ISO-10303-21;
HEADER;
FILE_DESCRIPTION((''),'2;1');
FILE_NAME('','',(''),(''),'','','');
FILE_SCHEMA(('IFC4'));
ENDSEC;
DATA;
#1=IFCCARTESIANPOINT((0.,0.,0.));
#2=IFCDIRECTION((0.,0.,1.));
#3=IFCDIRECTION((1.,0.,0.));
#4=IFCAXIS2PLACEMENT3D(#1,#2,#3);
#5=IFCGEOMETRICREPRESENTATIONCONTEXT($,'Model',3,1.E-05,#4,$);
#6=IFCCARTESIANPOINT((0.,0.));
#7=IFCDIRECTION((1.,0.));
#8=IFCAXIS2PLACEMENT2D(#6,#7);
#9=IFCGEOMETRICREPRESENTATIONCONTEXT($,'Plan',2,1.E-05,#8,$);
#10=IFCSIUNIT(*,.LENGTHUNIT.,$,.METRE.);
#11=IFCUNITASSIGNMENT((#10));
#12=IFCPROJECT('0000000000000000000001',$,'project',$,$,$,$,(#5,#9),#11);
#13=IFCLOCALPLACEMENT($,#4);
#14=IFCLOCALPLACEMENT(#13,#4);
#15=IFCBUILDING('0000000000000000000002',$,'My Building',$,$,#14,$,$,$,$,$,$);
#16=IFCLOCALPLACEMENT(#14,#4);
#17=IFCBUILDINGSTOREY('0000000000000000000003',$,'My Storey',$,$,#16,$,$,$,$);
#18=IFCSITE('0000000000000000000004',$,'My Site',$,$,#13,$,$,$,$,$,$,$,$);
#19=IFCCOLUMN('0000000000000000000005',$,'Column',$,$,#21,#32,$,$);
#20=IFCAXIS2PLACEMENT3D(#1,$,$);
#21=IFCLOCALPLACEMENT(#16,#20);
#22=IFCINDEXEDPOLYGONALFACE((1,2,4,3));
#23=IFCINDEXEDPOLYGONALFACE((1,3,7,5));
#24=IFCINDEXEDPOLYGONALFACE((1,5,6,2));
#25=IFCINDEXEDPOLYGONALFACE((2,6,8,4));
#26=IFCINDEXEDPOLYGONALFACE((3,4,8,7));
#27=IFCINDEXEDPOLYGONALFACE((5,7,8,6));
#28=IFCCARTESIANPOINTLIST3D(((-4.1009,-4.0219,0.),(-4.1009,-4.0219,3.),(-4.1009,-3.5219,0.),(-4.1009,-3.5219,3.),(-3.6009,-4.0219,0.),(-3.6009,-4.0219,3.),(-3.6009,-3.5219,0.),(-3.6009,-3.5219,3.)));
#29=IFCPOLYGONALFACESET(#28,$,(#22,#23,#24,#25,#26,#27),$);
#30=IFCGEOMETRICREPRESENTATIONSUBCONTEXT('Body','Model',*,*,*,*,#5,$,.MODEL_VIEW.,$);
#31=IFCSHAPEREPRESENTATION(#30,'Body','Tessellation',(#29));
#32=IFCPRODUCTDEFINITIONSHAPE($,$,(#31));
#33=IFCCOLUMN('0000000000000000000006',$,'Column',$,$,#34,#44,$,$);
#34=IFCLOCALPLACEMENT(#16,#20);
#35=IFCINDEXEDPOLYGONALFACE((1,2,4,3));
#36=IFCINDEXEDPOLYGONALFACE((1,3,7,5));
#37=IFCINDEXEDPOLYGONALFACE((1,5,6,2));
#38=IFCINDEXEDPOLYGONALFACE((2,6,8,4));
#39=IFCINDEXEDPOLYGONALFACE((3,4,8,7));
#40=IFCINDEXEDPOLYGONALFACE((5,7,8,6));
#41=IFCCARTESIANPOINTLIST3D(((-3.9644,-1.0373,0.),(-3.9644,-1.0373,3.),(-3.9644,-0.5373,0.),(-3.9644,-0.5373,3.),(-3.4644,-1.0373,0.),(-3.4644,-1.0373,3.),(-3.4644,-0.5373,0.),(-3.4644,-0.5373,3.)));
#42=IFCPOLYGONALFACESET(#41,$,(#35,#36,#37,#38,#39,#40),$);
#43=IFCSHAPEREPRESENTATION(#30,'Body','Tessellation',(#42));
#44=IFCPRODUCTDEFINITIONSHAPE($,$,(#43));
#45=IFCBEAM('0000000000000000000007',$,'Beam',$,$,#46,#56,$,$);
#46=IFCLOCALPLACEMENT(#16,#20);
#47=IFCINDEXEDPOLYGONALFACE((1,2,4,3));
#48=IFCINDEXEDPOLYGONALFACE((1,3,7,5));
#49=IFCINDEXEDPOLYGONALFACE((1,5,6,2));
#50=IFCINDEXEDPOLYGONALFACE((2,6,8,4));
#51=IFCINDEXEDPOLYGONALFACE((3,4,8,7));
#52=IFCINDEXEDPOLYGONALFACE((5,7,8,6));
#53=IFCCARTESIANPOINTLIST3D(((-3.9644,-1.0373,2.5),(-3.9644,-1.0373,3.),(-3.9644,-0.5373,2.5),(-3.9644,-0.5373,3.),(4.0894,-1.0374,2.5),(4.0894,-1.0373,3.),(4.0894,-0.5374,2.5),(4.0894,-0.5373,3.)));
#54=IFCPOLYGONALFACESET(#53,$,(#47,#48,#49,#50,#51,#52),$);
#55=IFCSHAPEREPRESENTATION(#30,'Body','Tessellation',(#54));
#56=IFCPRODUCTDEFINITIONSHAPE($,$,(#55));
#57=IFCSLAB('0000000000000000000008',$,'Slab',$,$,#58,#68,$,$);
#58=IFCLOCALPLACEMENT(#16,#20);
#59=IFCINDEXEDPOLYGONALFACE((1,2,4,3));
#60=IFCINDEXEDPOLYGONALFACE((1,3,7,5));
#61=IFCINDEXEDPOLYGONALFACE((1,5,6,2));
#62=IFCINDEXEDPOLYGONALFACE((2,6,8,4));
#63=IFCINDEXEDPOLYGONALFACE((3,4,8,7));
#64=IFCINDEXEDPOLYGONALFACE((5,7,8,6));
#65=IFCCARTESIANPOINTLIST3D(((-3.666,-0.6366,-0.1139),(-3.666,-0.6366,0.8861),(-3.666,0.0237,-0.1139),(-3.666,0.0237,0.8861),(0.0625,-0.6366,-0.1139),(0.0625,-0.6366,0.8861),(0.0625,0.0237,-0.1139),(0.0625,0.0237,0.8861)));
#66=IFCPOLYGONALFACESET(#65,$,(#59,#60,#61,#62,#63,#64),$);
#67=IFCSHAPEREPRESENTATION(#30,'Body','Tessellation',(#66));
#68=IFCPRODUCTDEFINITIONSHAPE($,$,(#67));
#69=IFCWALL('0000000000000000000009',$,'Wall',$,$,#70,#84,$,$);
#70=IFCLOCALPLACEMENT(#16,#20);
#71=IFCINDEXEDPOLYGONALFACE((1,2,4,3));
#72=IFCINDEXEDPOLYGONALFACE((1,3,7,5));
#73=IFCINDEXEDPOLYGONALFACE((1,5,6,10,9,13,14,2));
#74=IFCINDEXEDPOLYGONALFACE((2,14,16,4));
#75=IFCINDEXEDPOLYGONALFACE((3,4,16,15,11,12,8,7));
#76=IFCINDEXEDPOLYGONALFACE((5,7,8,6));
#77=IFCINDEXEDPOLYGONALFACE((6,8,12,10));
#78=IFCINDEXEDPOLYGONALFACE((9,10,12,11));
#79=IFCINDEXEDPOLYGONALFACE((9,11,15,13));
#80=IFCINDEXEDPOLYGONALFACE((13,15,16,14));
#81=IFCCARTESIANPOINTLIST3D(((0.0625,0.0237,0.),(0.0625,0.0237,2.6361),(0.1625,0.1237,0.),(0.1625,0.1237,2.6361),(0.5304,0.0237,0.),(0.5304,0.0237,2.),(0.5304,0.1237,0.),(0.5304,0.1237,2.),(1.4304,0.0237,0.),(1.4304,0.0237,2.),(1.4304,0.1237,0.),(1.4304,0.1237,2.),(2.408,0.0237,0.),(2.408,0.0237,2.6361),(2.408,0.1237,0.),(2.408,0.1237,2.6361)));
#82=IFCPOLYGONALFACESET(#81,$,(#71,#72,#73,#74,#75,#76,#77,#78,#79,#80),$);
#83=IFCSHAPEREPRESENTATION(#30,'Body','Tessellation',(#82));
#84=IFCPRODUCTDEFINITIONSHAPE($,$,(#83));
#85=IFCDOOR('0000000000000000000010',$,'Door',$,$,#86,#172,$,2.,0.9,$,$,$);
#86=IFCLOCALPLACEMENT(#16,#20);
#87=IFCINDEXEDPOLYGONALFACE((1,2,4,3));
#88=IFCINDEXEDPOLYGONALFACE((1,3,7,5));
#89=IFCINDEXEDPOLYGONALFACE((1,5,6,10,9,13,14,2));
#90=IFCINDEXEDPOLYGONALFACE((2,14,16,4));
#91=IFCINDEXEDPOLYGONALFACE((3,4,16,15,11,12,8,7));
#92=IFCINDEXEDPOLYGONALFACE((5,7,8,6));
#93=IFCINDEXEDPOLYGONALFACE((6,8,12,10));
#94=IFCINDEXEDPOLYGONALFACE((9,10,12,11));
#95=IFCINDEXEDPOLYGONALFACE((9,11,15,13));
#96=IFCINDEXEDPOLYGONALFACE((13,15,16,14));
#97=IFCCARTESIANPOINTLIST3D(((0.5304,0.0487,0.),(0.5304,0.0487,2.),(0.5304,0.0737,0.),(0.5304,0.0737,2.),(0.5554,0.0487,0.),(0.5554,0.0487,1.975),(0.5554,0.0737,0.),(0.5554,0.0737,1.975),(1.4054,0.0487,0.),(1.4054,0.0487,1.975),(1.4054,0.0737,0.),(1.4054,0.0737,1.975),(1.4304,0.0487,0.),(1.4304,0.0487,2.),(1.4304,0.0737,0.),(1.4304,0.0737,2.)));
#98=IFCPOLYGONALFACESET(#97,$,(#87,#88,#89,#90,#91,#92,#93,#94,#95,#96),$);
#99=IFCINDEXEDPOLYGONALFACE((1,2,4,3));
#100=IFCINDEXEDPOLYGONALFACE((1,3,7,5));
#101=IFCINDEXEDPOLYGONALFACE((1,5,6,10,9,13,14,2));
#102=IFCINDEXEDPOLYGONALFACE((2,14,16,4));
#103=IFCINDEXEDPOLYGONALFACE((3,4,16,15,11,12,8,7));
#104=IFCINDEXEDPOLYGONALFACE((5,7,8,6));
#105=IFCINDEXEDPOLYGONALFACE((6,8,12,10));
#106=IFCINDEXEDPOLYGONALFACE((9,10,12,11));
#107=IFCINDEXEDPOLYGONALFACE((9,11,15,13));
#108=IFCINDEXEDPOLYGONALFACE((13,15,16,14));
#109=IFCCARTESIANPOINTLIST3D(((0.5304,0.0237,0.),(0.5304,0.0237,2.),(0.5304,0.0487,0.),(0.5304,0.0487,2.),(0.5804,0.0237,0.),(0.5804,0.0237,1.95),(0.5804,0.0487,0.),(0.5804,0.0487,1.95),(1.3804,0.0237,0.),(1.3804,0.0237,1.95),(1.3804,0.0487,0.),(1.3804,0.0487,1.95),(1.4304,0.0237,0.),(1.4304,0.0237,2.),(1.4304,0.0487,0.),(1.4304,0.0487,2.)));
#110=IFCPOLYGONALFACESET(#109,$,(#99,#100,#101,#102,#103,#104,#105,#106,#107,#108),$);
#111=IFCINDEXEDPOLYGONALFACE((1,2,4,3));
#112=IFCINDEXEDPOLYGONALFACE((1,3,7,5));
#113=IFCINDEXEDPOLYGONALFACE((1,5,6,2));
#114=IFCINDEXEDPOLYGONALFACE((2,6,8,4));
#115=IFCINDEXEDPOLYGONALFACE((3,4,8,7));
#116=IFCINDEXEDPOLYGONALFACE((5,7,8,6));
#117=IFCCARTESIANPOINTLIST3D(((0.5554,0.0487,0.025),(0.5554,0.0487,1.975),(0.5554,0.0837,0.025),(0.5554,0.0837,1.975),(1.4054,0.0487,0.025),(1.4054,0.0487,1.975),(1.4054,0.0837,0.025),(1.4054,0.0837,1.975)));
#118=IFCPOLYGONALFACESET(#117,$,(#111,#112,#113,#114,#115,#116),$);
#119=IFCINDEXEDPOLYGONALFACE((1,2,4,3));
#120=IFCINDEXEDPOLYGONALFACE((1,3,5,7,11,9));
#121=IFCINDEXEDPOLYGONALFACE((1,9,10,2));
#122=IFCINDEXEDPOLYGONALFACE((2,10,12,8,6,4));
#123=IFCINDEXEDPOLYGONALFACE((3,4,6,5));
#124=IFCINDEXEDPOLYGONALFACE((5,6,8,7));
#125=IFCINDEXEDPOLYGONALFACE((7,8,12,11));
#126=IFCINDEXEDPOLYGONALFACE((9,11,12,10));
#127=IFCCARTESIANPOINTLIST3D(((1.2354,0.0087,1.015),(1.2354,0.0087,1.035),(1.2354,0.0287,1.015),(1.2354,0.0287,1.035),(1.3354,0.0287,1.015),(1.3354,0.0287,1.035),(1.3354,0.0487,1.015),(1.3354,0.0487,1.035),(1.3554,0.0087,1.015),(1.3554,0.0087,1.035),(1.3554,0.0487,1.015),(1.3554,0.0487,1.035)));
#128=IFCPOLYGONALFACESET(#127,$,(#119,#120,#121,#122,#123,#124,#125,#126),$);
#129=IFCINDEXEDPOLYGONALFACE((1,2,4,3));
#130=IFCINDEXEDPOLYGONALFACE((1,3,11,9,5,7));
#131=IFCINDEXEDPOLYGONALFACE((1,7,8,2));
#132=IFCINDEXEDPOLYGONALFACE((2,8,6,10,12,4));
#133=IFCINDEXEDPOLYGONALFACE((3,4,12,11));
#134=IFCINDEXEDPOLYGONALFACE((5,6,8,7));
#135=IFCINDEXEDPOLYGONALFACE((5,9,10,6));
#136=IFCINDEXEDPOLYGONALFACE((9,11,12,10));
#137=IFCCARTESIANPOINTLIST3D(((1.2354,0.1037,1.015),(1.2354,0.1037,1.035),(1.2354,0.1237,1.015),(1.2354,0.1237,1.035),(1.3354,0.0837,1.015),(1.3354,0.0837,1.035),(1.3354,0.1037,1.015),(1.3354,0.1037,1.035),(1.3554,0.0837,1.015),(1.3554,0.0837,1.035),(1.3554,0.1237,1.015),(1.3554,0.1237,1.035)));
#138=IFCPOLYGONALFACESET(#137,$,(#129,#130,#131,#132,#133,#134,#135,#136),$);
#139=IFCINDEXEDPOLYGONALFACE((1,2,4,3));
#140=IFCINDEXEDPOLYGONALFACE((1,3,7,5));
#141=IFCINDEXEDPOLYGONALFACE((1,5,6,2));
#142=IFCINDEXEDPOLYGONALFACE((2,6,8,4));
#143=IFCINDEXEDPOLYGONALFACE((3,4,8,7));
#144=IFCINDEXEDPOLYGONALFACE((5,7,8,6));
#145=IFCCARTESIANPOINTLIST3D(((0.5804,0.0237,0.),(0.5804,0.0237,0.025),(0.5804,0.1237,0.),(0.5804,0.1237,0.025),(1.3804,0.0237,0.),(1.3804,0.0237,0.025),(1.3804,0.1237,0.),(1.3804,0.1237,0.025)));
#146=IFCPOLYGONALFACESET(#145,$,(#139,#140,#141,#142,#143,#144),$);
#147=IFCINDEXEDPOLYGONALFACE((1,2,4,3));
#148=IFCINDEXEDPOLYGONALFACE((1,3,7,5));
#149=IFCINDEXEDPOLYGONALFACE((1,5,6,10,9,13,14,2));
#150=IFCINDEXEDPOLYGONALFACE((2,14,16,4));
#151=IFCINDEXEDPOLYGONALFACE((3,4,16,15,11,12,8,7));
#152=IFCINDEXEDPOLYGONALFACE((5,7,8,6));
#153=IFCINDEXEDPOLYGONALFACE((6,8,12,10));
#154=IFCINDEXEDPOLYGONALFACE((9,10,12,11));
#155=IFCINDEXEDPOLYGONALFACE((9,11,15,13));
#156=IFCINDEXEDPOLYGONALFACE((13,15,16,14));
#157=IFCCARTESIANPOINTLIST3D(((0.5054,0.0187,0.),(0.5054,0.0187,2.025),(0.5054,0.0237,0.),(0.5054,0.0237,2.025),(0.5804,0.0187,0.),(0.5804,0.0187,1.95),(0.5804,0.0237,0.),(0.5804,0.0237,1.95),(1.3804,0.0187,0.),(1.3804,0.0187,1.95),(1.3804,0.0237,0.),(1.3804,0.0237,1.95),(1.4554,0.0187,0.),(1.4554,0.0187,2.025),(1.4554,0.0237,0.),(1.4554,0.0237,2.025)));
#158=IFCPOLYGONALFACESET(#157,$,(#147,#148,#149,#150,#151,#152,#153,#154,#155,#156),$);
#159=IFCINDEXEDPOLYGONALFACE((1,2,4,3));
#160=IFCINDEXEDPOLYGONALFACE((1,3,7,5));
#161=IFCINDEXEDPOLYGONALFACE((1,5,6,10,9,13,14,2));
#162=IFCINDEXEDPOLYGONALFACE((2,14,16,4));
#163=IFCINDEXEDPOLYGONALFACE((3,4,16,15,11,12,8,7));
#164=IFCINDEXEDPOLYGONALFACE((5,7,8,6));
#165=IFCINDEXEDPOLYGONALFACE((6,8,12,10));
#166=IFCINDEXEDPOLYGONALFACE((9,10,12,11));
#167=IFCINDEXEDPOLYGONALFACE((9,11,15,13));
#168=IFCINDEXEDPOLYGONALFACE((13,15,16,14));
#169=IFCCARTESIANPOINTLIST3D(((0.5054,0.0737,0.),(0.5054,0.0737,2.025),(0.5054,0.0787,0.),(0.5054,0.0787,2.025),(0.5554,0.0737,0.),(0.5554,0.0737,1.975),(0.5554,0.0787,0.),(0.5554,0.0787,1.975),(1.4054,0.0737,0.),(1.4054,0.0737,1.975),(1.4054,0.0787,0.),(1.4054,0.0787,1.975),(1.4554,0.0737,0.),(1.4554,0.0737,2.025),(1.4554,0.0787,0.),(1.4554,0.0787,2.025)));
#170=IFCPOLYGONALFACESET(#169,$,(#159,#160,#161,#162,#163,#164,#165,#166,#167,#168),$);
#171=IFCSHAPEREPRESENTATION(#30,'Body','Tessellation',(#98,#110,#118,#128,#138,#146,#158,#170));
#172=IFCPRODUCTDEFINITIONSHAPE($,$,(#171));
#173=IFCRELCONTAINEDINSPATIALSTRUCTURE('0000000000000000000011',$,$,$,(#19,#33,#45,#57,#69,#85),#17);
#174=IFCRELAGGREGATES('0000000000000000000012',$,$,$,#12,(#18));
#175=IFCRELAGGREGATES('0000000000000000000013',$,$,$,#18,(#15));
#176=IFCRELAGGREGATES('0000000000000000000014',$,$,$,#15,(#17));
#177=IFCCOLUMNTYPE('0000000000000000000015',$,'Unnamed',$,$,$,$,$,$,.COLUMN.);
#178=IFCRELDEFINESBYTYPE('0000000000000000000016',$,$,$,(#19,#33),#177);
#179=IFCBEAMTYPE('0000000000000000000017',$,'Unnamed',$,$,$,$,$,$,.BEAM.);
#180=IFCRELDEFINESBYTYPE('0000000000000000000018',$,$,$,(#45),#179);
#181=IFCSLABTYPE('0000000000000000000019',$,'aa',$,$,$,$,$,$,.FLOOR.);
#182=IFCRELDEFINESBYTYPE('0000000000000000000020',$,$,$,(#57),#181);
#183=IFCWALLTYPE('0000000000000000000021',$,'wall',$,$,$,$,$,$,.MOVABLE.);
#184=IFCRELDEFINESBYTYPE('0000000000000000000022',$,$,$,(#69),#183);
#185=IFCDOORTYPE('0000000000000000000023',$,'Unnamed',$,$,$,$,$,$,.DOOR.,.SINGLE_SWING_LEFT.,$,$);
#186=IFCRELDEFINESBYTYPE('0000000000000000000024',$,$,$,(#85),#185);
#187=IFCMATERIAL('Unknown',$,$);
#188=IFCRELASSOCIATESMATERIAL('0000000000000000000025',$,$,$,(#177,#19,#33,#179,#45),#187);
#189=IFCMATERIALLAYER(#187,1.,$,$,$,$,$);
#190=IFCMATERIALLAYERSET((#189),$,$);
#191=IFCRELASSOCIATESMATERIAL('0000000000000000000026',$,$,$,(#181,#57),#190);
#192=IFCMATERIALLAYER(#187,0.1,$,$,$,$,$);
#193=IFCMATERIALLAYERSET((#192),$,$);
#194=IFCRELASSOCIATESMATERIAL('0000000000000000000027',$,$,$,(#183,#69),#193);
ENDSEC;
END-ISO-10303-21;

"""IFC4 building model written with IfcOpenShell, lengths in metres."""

from ifc_helpers import new_model, entity, si_unit, frame, origin_with_axes, origin_2d_with_axis, place, context, subcontext, project, spatial, line, indexed_curve, rectangle, outline, extrude, shape, source, transform, mapped, material, layer, layer_set, layer_usage, material_profile, profile_set, profile_usage, type_object, type_shapes, element, fill, save


model = new_model("IFC4")

# Units and contexts
model_context = context("Model", 3, precision=1e-05, world=origin_with_axes())
plan_context = context("Plan", 2, precision=1e-05, world=origin_2d_with_axis())
body_context_1 = subcontext(model_context, "Body", "Model", "MODEL_VIEW")
body_context_2 = subcontext(plan_context, "Body", "Plan", "PLAN_VIEW")
ifc_project = project(units=[si_unit("LENGTHUNIT", "METRE")], contexts=[model_context, plan_context])

# Site, building, storey
site_placement = place(None, origin_with_axes())
site = spatial("IfcSite", under=ifc_project, at=site_placement, Name="My Site")
building_placement = place(site_placement, origin_with_axes())
building = spatial("IfcBuilding", under=site, at=building_placement, Name="My Building")
storey_placement = place(building_placement, origin_with_axes())
storey = spatial("IfcBuildingStorey", under=building, at=storey_placement, Name="My Storey")

# Columns
ifc_material = material(Name="Unknown")
ifc_material_profile_1 = material_profile(ifc_material, rectangle(XDim=0.5, YDim=0.5))
ifc_profile_set_1 = profile_set([ifc_material_profile_1])
ifc_profile_usage_1 = profile_usage(ifc_profile_set_1, cardinal=5)
column_type = type_object("IfcColumnType", Name="Unnamed", PredefinedType="COLUMN", material=ifc_profile_set_1)
column_1_placement = place(storey_placement, frame((-3.8509, -3.7719, 0.0), z_axis=(0.0, 0.0, 1.0), x_axis=(1.0, 0.0, 0.0)))
element("IfcColumn", 1, at=column_1_placement, inside=storey, type_object=column_type, material=ifc_profile_usage_1, Name="Column", context=body_context_1, shape_type="SweptSolid", body=[
    extrude(rectangle(XDim=0.5, YDim=0.5), origin_with_axes(), (0.0, 0.0, 1.0), 3.0),
])
ifc_profile_usage_2 = profile_usage(ifc_profile_set_1, cardinal=5)
column_2_placement = place(storey_placement, frame((-3.7144, -0.7873, 0.0), z_axis=(0.0, 0.0, 1.0), x_axis=(1.0, 0.0, 0.0)))
element("IfcColumn", 2, at=column_2_placement, inside=storey, type_object=column_type, material=ifc_profile_usage_2, Name="Column", context=body_context_1, shape_type="SweptSolid", body=[
    extrude(rectangle(XDim=0.5, YDim=0.5), origin_with_axes(), (0.0, 0.0, 1.0), 3.0),
])

# Beam
ifc_material_profile_2 = material_profile(ifc_material, rectangle(XDim=0.5, YDim=0.5))
ifc_profile_set_2 = profile_set([ifc_material_profile_2])
ifc_profile_usage_3 = profile_usage(ifc_profile_set_2, cardinal=5)
beam_type = type_object("IfcBeamType", Name="Unnamed", PredefinedType="BEAM", material=ifc_profile_set_2)
beam_placement = place(storey_placement, frame((-3.9644, -0.7873, 2.75), z_axis=(1.0, 0.0, 0.0), x_axis=(0.0, 1.0, 0.0)))
element("IfcBeam", 3, at=beam_placement, inside=storey, type_object=beam_type, material=ifc_profile_usage_3, Name="Beam", context=body_context_1, shape_type="SweptSolid", body=[
    extrude(rectangle(XDim=0.5, YDim=0.5), origin_with_axes(), (0.0, 0.0, 1.0), 8.0538),
])

# Slab
ifc_layer_1 = layer(ifc_material, 1.0)
ifc_layer_set_1 = layer_set([ifc_layer_1])
ifc_layer_usage_1 = layer_usage(ifc_layer_set_1, "AXIS3", "POSITIVE", -1.0)
slab_type = type_object("IfcSlabType", Name="aa", PredefinedType="FLOOR", material=ifc_layer_set_1)
slab_placement = place(storey_placement, frame((0.0625, 0.0237, 0.8861), z_axis=(0.0, 0.0, 1.0), x_axis=(1.0, 0.0, 0.0)))
element("IfcSlab", 4, at=slab_placement, inside=storey, type_object=slab_type, material=ifc_layer_usage_1, Name="Slab", context=body_context_1, shape_type="SweptSolid", body=[
    extrude(outline(indexed_curve([(0.0, 0.0), (0.0, -0.6603), (-3.7285, -0.6603), (-3.7285, 0.0), (0.0, 0.0)])), frame((0.0, 0.0, -1.0), z_axis=(0.0, 0.0, 1.0), x_axis=(1.0, 0.0, 0.0)), (0.0, 0.0, 1.0), 1.0),
])

# Wall, opening, door
ifc_layer_2 = layer(ifc_material, 0.1)
ifc_layer_set_2 = layer_set([ifc_layer_2])
ifc_layer_usage_2 = layer_usage(ifc_layer_set_2, "AXIS2", "POSITIVE", 0.0)
wall_type = type_object("IfcWallType", Name="wall", PredefinedType="MOVABLE", material=ifc_layer_set_2)
wall_placement = place(storey_placement, frame((0.0625, 0.0237, 0.0), z_axis=(0.0, 0.0, 1.0), x_axis=(1.0, 0.0, 0.0)))
wall = element("IfcWall", 5, at=wall_placement, inside=storey, type_object=wall_type, material=ifc_layer_usage_2, Name="Wall", context=body_context_1, shape_type="SweptSolid", body=[
    extrude(outline(indexed_curve([(0.0, 0.0), (0.1, 0.1), (2.3454, 0.1), (2.3454, 0.0)], segments=[line(1, 2, 3, 4, 1)])), origin_with_axes(), (0.0, 0.0, 1.0), 2.6361),
])
shared_shape_1 = source(origin_with_axes(), body_context_1, "Body", "SweptSolid", [
    extrude(outline(indexed_curve([(0.0, 0.0), (0.9, 0.0), (0.9, 2.0), (0.0, 2.0)], segments=[line(1, 2, 3, 4, 1)])), frame((0.0, -0.6, 0.0), z_axis=(0.0, -1.0, 0.0), x_axis=(1.0, 0.0, 0.0)), (0.0, 0.0, -1.0), 1.2),
])
opening_placement = place(wall_placement, frame((0.4679, 0.0, 0.0), z_axis=(0.0, 0.0, 1.0), x_axis=(1.0, 0.0, 0.0)))
opening = element("IfcOpeningElement", 6, at=opening_placement, cuts=wall, PredefinedType="OPENING", context=body_context_1, shape_type="MappedRepresentation", body=[
    mapped(shared_shape_1, transform((0.0, 0.0, 0.0), x_axis=(1.0, 0.0, 0.0), y_axis=(0.0, 1.0, 0.0), z_axis=(0.0, 0.0, 1.0), scale=1.0)),
])
door_type = type_object("IfcDoorType", Name="Unnamed", OperationType="SINGLE_SWING_LEFT", PredefinedType="DOOR")
shared_shape_2 = source(origin_with_axes(), body_context_1, "Body", "SweptSolid", [
    extrude(outline(indexed_curve([(0.0, 0.0), (0.0, 2.0), (0.9, 2.0), (0.9, 0.0), (0.875, 0.0), (0.875, 1.975), (0.025, 1.975), (0.025, 0.0)], segments=[line(1, 2, 3, 4, 5, 6, 7, 8, 1)])), frame((0.0, 0.025, 0.0), z_axis=(0.0, -1.0, 0.0), x_axis=(1.0, 0.0, 0.0)), (0.0, 0.0, -1.0), 0.025),
    extrude(outline(indexed_curve([(0.0, 0.0), (0.0, 2.0), (0.9, 2.0), (0.9, 0.0), (0.85, 0.0), (0.85, 1.95), (0.05, 1.95), (0.05, 0.0)], segments=[line(1, 2, 3, 4, 5, 6, 7, 8, 1)])), frame((0.0, 0.0, 0.0), z_axis=(0.0, -1.0, 0.0), x_axis=(1.0, 0.0, 0.0)), (0.0, 0.0, -1.0), 0.025),
    extrude(outline(indexed_curve([(0.0, 0.0), (0.85, 0.0), (0.85, 0.035), (0.0, 0.035)], segments=[line(1, 2, 3, 4, 1)])), frame((0.025, 0.025, 0.025), z_axis=(0.0, 0.0, 1.0), x_axis=(1.0, 0.0, 0.0)), (0.0, 0.0, 1.0), 1.95),
    extrude(outline(indexed_curve([(0.0, 0.0), (0.0, -0.04), (-0.12, -0.04), (-0.12, -0.02), (-0.02, -0.02), (-0.02, 0.0)], segments=[line(1, 2, 3, 4, 5, 6, 1)])), frame((0.825, 0.025, 1.015), z_axis=(0.0, 0.0, 1.0), x_axis=(1.0, 0.0, 0.0)), (0.0, 0.0, 1.0), 0.02),
    extrude(outline(indexed_curve([(0.0, 0.0), (0.0, 0.04), (-0.12, 0.04), (-0.12, 0.02), (-0.02, 0.02), (-0.02, 0.0)], segments=[line(1, 2, 3, 4, 5, 6, 1)])), frame((0.825, 0.06, 1.015), z_axis=(0.0, 0.0, 1.0), x_axis=(1.0, 0.0, 0.0)), (0.0, 0.0, 1.0), 0.02),
    extrude(outline(indexed_curve([(0.0, 0.0), (0.8, 0.0), (0.8, 0.1), (0.0, 0.1)], segments=[line(1, 2, 3, 4, 1)])), frame((0.05, 0.0, 0.0), z_axis=(0.0, 0.0, 1.0), x_axis=(1.0, 0.0, 0.0)), (0.0, 0.0, 1.0), 0.025),
    extrude(outline(indexed_curve([(0.0, 0.0), (0.0, 2.025), (0.95, 2.025), (0.95, 0.0), (0.875, 0.0), (0.875, 1.95), (0.075, 1.95), (0.075, 0.0)], segments=[line(1, 2, 3, 4, 5, 6, 7, 8, 1)])), frame((-0.025, -0.005, 0.0), z_axis=(0.0, -1.0, 0.0), x_axis=(1.0, 0.0, 0.0)), (0.0, 0.0, -1.0), 0.005),
    extrude(outline(indexed_curve([(0.0, 0.0), (0.0, 2.025), (0.95, 2.025), (0.95, 0.0), (0.9, 0.0), (0.9, 1.975), (0.05, 1.975), (0.05, 0.0)], segments=[line(1, 2, 3, 4, 5, 6, 7, 8, 1)])), frame((-0.025, 0.05, 0.0), z_axis=(0.0, -1.0, 0.0), x_axis=(1.0, 0.0, 0.0)), (0.0, 0.0, -1.0), 0.005),
])
shared_shape_3 = source(origin_with_axes(), body_context_2, "Body", "Curve2D", [
    entity("IfcIndexedPolyCurve", entity("IfcCartesianPointList2D", [[0.0, 0.0], [0.0, 0.05], [0.025, 0.05], [0.025, 0.025], [0.05, 0.025], [0.05, 0.0]]), [entity("IfcLineIndex", [1, 2, 3, 4, 5, 6, 1])]),
    entity("IfcIndexedPolyCurve", entity("IfcCartesianPointList2D", [[0.9, 0.0], [0.9, 0.05], [0.875, 0.05], [0.875, 0.025], [0.85, 0.025], [0.85, 0.0]]), [entity("IfcLineIndex", [1, 2, 3, 4, 5, 6, 1])]),
    entity("IfcTrimmedCurve", entity("IfcEllipse", entity("IfcAxis2Placement2D", entity("IfcCartesianPoint", [0.06, 0.05]), entity("IfcDirection", [1.0, 0.0])), 0.815, 0.85), [entity("IfcCartesianPoint", [0.875, 0.05])], [entity("IfcCartesianPoint", [0.06, 0.9])], True, "CARTESIAN"),
    entity("IfcIndexedPolyCurve", entity("IfcCartesianPointList2D", [[0.025, 0.05], [0.06, 0.05], [0.06, 0.9], [0.025, 0.9]]), [entity("IfcLineIndex", [1, 2, 3, 4, 1])]),
])
type_shapes(door_type, [shared_shape_2, shared_shape_3])
door_placement = place(opening_placement, origin_with_axes())
door = element("IfcDoor", 7, at=door_placement, inside=storey, type_object=door_type, Name="Door", OverallHeight=2.0, OverallWidth=0.9, shapes=[
    shape(body_context_1, "Body", "MappedRepresentation", [mapped(shared_shape_2, transform((0.0, 0.0, 0.0), x_axis=(1.0, 0.0, 0.0), y_axis=(0.0, 1.0, 0.0), z_axis=(0.0, 0.0, 1.0), scale=1.0))]),
    shape(body_context_2, "Body", "MappedRepresentation", [mapped(shared_shape_3, transform((0.0, 0.0, 0.0), x_axis=(1.0, 0.0, 0.0), y_axis=(0.0, 1.0, 0.0), z_axis=(0.0, 0.0, 1.0), scale=1.0))]),
])
fill(opening, door)

save(model, "model.ifc")
